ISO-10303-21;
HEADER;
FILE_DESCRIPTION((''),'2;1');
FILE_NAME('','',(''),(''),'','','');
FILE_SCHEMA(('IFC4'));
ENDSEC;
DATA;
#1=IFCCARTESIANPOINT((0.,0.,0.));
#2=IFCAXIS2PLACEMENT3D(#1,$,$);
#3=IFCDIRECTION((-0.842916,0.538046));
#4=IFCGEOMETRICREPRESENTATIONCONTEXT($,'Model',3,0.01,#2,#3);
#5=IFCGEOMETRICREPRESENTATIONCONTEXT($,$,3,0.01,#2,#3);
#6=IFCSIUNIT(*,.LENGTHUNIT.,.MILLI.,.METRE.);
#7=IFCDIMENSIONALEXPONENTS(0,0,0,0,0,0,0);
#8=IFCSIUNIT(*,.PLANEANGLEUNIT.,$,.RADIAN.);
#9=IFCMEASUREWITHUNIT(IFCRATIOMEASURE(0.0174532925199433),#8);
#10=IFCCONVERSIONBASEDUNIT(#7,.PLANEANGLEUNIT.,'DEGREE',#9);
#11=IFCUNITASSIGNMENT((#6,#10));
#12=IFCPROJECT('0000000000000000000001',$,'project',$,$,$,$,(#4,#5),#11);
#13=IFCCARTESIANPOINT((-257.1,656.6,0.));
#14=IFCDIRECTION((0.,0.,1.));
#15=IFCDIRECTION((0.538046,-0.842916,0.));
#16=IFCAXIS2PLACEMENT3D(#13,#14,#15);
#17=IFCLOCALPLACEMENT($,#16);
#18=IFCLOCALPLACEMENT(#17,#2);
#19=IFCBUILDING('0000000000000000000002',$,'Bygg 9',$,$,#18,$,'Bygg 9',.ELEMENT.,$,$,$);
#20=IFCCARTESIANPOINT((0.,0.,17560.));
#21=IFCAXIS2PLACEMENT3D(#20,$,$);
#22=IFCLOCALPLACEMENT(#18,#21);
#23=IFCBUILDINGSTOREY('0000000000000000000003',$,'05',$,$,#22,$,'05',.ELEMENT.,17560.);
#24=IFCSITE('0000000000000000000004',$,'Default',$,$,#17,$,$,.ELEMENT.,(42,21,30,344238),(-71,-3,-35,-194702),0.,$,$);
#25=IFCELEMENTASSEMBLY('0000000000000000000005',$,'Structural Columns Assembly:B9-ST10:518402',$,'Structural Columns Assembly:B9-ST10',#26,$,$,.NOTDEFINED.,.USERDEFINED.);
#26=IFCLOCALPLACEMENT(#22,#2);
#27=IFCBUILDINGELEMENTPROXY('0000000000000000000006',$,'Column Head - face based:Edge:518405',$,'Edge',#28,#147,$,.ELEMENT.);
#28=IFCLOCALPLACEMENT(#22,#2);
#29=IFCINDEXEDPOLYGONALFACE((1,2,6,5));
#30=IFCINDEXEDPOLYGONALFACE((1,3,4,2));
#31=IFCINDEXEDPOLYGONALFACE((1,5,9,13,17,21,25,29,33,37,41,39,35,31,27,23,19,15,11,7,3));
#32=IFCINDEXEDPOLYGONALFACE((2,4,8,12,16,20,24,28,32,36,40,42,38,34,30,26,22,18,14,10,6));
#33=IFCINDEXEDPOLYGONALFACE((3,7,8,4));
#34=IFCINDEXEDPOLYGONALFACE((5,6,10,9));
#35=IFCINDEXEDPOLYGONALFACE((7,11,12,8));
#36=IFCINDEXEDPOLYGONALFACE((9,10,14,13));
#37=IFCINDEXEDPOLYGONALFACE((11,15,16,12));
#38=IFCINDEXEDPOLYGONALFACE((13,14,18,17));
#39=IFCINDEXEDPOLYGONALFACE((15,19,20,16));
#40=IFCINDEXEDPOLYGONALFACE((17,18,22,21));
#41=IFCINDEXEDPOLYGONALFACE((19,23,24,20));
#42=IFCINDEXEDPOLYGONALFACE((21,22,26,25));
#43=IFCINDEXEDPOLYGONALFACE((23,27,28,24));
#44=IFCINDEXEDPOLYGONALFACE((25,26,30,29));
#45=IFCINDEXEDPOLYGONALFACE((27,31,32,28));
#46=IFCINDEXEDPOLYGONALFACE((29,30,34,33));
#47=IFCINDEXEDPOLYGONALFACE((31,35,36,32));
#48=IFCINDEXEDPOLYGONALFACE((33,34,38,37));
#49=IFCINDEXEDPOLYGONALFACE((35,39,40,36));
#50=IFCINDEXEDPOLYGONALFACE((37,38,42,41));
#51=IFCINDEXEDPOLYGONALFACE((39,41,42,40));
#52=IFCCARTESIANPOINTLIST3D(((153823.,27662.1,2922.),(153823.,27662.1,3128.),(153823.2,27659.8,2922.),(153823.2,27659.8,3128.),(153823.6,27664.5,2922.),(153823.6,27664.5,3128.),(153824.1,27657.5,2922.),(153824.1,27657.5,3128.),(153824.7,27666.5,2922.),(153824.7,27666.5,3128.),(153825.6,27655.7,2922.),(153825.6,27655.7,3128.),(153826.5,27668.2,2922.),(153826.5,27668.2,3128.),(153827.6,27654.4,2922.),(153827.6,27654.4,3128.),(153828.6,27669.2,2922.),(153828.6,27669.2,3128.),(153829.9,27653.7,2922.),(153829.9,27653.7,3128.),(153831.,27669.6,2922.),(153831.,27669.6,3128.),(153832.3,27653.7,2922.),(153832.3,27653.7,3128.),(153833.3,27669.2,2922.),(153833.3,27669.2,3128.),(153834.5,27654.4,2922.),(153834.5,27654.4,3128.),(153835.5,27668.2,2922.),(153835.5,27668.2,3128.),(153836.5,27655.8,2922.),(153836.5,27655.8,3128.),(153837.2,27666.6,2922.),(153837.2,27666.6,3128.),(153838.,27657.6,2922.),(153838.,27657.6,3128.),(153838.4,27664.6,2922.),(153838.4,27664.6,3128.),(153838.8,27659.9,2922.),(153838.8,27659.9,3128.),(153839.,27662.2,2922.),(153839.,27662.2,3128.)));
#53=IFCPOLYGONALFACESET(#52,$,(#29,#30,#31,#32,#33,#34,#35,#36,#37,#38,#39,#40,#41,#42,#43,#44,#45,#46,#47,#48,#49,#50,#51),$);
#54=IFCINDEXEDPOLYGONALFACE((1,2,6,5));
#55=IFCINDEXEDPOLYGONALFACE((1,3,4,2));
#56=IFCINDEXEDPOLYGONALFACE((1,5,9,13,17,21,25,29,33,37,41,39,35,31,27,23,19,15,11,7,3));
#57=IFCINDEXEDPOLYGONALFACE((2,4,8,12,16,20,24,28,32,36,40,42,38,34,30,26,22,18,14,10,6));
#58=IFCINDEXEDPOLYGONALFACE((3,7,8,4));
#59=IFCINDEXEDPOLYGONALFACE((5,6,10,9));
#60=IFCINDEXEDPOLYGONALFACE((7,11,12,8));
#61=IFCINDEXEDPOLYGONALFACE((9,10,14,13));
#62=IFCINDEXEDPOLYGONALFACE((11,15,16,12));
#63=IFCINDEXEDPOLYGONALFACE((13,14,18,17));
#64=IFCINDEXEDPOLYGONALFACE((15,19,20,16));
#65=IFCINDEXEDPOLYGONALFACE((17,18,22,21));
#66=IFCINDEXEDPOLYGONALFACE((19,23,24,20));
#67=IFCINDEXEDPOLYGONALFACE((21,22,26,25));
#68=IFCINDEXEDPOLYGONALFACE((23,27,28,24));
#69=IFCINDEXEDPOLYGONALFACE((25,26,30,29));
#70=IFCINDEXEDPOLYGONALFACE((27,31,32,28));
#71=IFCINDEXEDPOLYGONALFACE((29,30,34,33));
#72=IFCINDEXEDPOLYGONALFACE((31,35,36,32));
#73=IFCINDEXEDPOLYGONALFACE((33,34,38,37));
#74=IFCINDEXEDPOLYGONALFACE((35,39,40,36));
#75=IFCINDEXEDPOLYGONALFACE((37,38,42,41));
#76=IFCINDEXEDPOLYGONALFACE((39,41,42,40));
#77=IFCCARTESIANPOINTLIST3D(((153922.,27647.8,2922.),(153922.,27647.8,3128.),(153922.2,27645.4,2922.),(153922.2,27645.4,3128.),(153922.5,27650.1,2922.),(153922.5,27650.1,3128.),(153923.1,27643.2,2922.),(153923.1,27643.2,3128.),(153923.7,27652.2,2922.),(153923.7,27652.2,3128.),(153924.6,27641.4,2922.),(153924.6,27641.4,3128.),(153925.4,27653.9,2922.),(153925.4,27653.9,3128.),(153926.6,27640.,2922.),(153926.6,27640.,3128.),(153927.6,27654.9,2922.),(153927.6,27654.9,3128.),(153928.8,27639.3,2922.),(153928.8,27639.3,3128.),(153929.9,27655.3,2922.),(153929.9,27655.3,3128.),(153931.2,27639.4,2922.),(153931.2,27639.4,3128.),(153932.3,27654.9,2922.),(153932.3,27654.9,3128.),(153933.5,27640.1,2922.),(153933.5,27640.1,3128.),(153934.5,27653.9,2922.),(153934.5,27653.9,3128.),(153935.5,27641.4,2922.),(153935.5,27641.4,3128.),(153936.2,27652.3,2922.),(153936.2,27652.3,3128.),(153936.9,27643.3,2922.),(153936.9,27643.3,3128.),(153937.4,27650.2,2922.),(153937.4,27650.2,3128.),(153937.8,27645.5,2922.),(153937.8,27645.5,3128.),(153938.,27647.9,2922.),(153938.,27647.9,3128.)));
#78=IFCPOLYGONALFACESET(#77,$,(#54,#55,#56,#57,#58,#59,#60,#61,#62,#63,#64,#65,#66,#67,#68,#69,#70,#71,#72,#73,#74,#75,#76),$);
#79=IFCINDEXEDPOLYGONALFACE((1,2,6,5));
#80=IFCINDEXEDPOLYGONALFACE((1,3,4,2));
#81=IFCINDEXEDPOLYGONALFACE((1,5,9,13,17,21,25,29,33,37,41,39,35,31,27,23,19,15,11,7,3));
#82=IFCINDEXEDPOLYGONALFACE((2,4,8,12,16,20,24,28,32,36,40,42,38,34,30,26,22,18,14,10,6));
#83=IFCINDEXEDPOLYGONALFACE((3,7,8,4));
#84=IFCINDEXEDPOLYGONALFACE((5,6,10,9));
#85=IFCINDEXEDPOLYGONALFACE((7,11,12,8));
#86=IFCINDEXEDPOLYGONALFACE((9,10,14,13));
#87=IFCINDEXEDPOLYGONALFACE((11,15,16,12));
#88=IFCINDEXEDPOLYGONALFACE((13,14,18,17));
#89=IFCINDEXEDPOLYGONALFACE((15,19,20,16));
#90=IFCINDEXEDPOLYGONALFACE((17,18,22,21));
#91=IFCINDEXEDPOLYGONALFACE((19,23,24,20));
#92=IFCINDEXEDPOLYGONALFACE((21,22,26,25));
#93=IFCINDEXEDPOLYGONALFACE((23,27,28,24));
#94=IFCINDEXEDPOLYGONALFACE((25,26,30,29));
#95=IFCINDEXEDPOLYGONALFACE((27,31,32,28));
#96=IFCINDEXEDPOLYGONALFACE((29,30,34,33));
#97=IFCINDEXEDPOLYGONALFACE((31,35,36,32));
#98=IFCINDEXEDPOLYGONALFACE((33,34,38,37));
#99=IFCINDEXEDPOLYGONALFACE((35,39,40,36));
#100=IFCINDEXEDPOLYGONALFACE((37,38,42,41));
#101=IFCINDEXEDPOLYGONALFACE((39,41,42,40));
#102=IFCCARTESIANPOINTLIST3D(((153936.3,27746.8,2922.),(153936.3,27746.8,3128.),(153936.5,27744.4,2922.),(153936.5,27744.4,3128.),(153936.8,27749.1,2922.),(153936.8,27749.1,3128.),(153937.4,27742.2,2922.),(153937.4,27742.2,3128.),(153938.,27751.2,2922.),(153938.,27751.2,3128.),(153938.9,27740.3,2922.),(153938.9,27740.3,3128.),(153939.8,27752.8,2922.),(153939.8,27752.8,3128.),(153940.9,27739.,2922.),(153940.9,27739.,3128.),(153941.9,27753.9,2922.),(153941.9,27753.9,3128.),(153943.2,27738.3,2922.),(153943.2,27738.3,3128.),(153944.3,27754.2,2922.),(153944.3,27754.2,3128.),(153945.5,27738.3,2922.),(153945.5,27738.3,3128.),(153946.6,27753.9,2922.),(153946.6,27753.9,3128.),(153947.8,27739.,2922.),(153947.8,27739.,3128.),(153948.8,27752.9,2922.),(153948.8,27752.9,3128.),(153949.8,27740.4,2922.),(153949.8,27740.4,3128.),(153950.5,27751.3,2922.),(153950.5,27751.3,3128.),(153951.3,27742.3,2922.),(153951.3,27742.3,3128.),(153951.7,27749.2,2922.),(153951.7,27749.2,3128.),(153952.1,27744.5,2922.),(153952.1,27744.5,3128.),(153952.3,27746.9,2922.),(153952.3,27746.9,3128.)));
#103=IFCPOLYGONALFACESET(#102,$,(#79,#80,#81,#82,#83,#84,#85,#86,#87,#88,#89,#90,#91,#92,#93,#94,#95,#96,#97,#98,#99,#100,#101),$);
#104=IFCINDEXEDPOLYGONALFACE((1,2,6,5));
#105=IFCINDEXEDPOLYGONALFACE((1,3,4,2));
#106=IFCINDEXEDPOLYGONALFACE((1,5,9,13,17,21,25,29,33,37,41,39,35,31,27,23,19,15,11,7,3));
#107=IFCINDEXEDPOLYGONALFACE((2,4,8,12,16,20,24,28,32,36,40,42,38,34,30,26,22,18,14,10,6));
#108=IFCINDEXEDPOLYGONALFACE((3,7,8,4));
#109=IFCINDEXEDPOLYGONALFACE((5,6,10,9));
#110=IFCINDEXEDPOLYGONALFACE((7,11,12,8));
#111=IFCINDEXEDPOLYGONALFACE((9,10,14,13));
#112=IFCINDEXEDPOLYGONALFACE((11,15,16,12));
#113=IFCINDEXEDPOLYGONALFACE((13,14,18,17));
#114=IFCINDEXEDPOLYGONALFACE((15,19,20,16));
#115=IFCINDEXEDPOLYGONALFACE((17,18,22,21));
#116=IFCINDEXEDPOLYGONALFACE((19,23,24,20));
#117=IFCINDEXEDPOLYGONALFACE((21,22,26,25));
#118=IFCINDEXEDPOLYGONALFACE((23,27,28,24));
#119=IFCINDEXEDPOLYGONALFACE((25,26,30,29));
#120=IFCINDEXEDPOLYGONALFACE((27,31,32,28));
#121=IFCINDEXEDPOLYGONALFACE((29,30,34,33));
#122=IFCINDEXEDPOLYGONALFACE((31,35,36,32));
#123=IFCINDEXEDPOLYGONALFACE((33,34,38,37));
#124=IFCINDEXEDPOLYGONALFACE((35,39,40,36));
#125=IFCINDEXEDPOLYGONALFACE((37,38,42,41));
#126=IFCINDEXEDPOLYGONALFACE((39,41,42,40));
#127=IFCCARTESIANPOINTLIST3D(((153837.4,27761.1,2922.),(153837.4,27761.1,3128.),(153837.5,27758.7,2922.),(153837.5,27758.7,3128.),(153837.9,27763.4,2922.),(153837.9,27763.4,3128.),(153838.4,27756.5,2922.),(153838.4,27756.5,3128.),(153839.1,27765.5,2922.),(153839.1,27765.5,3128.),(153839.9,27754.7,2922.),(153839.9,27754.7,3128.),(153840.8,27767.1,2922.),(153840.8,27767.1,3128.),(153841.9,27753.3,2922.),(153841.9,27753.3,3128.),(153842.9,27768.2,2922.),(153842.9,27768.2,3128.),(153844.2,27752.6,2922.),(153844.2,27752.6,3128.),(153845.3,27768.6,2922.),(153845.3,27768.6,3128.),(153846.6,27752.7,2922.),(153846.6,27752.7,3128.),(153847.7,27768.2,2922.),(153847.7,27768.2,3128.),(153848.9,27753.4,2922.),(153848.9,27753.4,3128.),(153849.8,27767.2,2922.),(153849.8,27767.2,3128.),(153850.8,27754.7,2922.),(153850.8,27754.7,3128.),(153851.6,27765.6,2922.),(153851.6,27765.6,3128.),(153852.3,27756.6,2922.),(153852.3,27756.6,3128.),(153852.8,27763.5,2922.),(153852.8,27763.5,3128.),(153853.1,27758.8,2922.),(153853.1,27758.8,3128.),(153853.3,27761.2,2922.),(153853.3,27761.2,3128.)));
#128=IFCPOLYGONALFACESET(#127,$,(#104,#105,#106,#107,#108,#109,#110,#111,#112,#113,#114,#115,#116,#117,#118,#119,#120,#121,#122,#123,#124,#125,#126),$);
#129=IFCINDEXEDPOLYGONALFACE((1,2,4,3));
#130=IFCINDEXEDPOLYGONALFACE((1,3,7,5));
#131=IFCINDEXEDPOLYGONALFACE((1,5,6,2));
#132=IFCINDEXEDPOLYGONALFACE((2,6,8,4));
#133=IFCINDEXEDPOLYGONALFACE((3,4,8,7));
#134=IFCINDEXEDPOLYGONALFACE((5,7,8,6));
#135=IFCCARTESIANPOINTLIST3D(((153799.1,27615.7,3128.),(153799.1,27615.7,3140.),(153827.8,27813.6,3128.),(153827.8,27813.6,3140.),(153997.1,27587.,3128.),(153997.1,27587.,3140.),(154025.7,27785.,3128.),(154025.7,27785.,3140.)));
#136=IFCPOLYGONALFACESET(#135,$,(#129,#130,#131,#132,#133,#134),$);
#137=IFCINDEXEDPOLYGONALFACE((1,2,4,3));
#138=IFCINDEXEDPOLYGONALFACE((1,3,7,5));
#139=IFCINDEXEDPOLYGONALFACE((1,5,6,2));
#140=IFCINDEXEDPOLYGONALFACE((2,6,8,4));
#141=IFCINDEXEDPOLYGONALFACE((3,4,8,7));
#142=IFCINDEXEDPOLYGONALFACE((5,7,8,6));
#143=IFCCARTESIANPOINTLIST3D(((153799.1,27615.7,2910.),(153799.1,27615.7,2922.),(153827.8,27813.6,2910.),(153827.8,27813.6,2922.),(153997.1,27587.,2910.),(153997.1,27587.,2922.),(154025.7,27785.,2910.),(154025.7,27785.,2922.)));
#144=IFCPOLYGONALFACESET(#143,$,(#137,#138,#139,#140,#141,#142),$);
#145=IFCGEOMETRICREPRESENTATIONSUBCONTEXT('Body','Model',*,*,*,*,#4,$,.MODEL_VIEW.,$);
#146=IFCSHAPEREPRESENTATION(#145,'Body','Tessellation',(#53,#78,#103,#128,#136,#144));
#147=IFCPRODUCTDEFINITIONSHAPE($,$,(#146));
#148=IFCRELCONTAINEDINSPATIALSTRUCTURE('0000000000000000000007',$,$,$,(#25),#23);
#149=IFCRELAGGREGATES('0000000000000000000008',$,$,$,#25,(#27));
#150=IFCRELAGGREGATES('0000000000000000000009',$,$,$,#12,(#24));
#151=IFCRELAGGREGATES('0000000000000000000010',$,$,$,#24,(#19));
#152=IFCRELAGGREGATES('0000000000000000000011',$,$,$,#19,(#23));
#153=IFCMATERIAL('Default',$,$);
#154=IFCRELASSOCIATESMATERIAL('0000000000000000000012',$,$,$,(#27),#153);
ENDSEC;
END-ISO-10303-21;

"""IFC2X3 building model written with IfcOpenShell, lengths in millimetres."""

from ifc_helpers import new_model, entity, si_unit, converted_unit, direction, frame, frame_2d, origin, origin_2d_with_axis, place, context, subcontext, project, spatial, rectangle, circle, extrude, source, transform, mapped, material, element, aggregate, save


model = new_model("IFC2X3")

# Units and contexts
model_context = context("Model", 3, precision=0.01, world=origin(), true_north=direction((-0.842916, 0.538046)))
context_of_model = context(None, 3, precision=0.01, world=origin(), true_north=direction((-0.842916, 0.538046)))
body_context = subcontext(model_context, "Body", "Model", "MODEL_VIEW")
ifc_project = project(units=[si_unit("LENGTHUNIT", "METRE", prefix="MILLI"), converted_unit("PLANEANGLEUNIT", "DEGREE", entity("IfcRatioMeasure", 0.0174532925199433), si_unit("PLANEANGLEUNIT", "RADIAN"), dimensions=[0, 0, 0, 0, 0, 0, 0])], contexts=[model_context, context_of_model])

# Site, building, storey
site_placement = place(None, frame((-257.1, 656.6, 0.0), z_axis=(0.0, 0.0, 1.0), x_axis=(0.538046, -0.842916, 0.0)))
site = spatial("IfcSite", under=ifc_project, at=site_placement, Name="Default", CompositionType="ELEMENT", RefLatitude=(42, 21, 30, 344238), RefLongitude=(-71, -3, -35, -194702), RefElevation=0.0)
building_placement = place(site_placement, origin())
building = spatial("IfcBuilding", under=site, at=building_placement, Name="Bygg 9", LongName="Bygg 9", CompositionType="ELEMENT")
storey_placement = place(building_placement, frame((0.0, 0.0, 17560.0)))
storey = spatial("IfcBuildingStorey", under=building, at=storey_placement, Name="05", LongName="05", CompositionType="ELEMENT", Elevation=17560.0)

# Element assembly
assembly_1_placement = place(storey_placement, origin())
assembly_1 = element("IfcElementAssembly", 1, at=assembly_1_placement, inside=storey, Name="Structural Columns Assembly:B9-ST10:518402", ObjectType="Structural Columns Assembly:B9-ST10", AssemblyPlace="NOTDEFINED", PredefinedType="USERDEFINED")

# Building element proxy
ifc_material_1 = material(Name="Default")
shared_shape_1 = source(origin(), body_context, "Body", "SweptSolid", [
    extrude(circle(Radius=8.0, at=frame_2d((0.0, 0.0), x_axis=(1.0, 0.0))), frame((50.0, -75.0, 12.0)), (0.0, 0.0, 1.0), 206.0),
    extrude(circle(Radius=8.0, at=frame_2d((0.0, 0.0), x_axis=(1.0, 0.0))), frame((50.0, 25.0, 12.0)), (0.0, 0.0, 1.0), 206.0),
    extrude(circle(Radius=8.0, at=frame_2d((0.0, 0.0), x_axis=(1.0, 0.0))), frame((-50.0, 25.0, 12.0)), (0.0, 0.0, 1.0), 206.0),
    extrude(circle(Radius=8.0, at=frame_2d((0.0, 0.0), x_axis=(1.0, 0.0))), frame((-50.0, -75.0, 12.0)), (0.0, 0.0, 1.0), 206.0),
    extrude(rectangle(XDim=200.0, YDim=200.0, at=origin_2d_with_axis()), frame((0.0, 0.0, 218.0), z_axis=(0.0, 0.0, 1.0), x_axis=(-1.0, 0.0, 0.0)), (0.0, 0.0, 1.0), 12.0),
    extrude(rectangle(XDim=200.0, YDim=200.0, at=origin_2d_with_axis()), frame((0.0, 0.0, 0.0), z_axis=(0.0, 0.0, 1.0), x_axis=(0.0, 1.0, 0.0)), (0.0, 0.0, 1.0), 12.0),
])
proxy_1_placement = place(assembly_1_placement, frame((153912.4, 27700.3, 2910.0), z_axis=(0.0, 0.0, 1.0), x_axis=(-0.143216, -0.989691, 0.0)))
proxy_1 = element("IfcBuildingElementProxy", 2, at=proxy_1_placement, material=ifc_material_1, Name="Column Head - face based:Edge:518405", ObjectType="Edge", CompositionType="ELEMENT", context=body_context, shape_type="MappedRepresentation", body=[
    mapped(shared_shape_1, transform((0.0, 0.0, 0.0), scale=1.0)),
])
aggregate(assembly_1, [proxy_1])

save(model, "model.ifc")
